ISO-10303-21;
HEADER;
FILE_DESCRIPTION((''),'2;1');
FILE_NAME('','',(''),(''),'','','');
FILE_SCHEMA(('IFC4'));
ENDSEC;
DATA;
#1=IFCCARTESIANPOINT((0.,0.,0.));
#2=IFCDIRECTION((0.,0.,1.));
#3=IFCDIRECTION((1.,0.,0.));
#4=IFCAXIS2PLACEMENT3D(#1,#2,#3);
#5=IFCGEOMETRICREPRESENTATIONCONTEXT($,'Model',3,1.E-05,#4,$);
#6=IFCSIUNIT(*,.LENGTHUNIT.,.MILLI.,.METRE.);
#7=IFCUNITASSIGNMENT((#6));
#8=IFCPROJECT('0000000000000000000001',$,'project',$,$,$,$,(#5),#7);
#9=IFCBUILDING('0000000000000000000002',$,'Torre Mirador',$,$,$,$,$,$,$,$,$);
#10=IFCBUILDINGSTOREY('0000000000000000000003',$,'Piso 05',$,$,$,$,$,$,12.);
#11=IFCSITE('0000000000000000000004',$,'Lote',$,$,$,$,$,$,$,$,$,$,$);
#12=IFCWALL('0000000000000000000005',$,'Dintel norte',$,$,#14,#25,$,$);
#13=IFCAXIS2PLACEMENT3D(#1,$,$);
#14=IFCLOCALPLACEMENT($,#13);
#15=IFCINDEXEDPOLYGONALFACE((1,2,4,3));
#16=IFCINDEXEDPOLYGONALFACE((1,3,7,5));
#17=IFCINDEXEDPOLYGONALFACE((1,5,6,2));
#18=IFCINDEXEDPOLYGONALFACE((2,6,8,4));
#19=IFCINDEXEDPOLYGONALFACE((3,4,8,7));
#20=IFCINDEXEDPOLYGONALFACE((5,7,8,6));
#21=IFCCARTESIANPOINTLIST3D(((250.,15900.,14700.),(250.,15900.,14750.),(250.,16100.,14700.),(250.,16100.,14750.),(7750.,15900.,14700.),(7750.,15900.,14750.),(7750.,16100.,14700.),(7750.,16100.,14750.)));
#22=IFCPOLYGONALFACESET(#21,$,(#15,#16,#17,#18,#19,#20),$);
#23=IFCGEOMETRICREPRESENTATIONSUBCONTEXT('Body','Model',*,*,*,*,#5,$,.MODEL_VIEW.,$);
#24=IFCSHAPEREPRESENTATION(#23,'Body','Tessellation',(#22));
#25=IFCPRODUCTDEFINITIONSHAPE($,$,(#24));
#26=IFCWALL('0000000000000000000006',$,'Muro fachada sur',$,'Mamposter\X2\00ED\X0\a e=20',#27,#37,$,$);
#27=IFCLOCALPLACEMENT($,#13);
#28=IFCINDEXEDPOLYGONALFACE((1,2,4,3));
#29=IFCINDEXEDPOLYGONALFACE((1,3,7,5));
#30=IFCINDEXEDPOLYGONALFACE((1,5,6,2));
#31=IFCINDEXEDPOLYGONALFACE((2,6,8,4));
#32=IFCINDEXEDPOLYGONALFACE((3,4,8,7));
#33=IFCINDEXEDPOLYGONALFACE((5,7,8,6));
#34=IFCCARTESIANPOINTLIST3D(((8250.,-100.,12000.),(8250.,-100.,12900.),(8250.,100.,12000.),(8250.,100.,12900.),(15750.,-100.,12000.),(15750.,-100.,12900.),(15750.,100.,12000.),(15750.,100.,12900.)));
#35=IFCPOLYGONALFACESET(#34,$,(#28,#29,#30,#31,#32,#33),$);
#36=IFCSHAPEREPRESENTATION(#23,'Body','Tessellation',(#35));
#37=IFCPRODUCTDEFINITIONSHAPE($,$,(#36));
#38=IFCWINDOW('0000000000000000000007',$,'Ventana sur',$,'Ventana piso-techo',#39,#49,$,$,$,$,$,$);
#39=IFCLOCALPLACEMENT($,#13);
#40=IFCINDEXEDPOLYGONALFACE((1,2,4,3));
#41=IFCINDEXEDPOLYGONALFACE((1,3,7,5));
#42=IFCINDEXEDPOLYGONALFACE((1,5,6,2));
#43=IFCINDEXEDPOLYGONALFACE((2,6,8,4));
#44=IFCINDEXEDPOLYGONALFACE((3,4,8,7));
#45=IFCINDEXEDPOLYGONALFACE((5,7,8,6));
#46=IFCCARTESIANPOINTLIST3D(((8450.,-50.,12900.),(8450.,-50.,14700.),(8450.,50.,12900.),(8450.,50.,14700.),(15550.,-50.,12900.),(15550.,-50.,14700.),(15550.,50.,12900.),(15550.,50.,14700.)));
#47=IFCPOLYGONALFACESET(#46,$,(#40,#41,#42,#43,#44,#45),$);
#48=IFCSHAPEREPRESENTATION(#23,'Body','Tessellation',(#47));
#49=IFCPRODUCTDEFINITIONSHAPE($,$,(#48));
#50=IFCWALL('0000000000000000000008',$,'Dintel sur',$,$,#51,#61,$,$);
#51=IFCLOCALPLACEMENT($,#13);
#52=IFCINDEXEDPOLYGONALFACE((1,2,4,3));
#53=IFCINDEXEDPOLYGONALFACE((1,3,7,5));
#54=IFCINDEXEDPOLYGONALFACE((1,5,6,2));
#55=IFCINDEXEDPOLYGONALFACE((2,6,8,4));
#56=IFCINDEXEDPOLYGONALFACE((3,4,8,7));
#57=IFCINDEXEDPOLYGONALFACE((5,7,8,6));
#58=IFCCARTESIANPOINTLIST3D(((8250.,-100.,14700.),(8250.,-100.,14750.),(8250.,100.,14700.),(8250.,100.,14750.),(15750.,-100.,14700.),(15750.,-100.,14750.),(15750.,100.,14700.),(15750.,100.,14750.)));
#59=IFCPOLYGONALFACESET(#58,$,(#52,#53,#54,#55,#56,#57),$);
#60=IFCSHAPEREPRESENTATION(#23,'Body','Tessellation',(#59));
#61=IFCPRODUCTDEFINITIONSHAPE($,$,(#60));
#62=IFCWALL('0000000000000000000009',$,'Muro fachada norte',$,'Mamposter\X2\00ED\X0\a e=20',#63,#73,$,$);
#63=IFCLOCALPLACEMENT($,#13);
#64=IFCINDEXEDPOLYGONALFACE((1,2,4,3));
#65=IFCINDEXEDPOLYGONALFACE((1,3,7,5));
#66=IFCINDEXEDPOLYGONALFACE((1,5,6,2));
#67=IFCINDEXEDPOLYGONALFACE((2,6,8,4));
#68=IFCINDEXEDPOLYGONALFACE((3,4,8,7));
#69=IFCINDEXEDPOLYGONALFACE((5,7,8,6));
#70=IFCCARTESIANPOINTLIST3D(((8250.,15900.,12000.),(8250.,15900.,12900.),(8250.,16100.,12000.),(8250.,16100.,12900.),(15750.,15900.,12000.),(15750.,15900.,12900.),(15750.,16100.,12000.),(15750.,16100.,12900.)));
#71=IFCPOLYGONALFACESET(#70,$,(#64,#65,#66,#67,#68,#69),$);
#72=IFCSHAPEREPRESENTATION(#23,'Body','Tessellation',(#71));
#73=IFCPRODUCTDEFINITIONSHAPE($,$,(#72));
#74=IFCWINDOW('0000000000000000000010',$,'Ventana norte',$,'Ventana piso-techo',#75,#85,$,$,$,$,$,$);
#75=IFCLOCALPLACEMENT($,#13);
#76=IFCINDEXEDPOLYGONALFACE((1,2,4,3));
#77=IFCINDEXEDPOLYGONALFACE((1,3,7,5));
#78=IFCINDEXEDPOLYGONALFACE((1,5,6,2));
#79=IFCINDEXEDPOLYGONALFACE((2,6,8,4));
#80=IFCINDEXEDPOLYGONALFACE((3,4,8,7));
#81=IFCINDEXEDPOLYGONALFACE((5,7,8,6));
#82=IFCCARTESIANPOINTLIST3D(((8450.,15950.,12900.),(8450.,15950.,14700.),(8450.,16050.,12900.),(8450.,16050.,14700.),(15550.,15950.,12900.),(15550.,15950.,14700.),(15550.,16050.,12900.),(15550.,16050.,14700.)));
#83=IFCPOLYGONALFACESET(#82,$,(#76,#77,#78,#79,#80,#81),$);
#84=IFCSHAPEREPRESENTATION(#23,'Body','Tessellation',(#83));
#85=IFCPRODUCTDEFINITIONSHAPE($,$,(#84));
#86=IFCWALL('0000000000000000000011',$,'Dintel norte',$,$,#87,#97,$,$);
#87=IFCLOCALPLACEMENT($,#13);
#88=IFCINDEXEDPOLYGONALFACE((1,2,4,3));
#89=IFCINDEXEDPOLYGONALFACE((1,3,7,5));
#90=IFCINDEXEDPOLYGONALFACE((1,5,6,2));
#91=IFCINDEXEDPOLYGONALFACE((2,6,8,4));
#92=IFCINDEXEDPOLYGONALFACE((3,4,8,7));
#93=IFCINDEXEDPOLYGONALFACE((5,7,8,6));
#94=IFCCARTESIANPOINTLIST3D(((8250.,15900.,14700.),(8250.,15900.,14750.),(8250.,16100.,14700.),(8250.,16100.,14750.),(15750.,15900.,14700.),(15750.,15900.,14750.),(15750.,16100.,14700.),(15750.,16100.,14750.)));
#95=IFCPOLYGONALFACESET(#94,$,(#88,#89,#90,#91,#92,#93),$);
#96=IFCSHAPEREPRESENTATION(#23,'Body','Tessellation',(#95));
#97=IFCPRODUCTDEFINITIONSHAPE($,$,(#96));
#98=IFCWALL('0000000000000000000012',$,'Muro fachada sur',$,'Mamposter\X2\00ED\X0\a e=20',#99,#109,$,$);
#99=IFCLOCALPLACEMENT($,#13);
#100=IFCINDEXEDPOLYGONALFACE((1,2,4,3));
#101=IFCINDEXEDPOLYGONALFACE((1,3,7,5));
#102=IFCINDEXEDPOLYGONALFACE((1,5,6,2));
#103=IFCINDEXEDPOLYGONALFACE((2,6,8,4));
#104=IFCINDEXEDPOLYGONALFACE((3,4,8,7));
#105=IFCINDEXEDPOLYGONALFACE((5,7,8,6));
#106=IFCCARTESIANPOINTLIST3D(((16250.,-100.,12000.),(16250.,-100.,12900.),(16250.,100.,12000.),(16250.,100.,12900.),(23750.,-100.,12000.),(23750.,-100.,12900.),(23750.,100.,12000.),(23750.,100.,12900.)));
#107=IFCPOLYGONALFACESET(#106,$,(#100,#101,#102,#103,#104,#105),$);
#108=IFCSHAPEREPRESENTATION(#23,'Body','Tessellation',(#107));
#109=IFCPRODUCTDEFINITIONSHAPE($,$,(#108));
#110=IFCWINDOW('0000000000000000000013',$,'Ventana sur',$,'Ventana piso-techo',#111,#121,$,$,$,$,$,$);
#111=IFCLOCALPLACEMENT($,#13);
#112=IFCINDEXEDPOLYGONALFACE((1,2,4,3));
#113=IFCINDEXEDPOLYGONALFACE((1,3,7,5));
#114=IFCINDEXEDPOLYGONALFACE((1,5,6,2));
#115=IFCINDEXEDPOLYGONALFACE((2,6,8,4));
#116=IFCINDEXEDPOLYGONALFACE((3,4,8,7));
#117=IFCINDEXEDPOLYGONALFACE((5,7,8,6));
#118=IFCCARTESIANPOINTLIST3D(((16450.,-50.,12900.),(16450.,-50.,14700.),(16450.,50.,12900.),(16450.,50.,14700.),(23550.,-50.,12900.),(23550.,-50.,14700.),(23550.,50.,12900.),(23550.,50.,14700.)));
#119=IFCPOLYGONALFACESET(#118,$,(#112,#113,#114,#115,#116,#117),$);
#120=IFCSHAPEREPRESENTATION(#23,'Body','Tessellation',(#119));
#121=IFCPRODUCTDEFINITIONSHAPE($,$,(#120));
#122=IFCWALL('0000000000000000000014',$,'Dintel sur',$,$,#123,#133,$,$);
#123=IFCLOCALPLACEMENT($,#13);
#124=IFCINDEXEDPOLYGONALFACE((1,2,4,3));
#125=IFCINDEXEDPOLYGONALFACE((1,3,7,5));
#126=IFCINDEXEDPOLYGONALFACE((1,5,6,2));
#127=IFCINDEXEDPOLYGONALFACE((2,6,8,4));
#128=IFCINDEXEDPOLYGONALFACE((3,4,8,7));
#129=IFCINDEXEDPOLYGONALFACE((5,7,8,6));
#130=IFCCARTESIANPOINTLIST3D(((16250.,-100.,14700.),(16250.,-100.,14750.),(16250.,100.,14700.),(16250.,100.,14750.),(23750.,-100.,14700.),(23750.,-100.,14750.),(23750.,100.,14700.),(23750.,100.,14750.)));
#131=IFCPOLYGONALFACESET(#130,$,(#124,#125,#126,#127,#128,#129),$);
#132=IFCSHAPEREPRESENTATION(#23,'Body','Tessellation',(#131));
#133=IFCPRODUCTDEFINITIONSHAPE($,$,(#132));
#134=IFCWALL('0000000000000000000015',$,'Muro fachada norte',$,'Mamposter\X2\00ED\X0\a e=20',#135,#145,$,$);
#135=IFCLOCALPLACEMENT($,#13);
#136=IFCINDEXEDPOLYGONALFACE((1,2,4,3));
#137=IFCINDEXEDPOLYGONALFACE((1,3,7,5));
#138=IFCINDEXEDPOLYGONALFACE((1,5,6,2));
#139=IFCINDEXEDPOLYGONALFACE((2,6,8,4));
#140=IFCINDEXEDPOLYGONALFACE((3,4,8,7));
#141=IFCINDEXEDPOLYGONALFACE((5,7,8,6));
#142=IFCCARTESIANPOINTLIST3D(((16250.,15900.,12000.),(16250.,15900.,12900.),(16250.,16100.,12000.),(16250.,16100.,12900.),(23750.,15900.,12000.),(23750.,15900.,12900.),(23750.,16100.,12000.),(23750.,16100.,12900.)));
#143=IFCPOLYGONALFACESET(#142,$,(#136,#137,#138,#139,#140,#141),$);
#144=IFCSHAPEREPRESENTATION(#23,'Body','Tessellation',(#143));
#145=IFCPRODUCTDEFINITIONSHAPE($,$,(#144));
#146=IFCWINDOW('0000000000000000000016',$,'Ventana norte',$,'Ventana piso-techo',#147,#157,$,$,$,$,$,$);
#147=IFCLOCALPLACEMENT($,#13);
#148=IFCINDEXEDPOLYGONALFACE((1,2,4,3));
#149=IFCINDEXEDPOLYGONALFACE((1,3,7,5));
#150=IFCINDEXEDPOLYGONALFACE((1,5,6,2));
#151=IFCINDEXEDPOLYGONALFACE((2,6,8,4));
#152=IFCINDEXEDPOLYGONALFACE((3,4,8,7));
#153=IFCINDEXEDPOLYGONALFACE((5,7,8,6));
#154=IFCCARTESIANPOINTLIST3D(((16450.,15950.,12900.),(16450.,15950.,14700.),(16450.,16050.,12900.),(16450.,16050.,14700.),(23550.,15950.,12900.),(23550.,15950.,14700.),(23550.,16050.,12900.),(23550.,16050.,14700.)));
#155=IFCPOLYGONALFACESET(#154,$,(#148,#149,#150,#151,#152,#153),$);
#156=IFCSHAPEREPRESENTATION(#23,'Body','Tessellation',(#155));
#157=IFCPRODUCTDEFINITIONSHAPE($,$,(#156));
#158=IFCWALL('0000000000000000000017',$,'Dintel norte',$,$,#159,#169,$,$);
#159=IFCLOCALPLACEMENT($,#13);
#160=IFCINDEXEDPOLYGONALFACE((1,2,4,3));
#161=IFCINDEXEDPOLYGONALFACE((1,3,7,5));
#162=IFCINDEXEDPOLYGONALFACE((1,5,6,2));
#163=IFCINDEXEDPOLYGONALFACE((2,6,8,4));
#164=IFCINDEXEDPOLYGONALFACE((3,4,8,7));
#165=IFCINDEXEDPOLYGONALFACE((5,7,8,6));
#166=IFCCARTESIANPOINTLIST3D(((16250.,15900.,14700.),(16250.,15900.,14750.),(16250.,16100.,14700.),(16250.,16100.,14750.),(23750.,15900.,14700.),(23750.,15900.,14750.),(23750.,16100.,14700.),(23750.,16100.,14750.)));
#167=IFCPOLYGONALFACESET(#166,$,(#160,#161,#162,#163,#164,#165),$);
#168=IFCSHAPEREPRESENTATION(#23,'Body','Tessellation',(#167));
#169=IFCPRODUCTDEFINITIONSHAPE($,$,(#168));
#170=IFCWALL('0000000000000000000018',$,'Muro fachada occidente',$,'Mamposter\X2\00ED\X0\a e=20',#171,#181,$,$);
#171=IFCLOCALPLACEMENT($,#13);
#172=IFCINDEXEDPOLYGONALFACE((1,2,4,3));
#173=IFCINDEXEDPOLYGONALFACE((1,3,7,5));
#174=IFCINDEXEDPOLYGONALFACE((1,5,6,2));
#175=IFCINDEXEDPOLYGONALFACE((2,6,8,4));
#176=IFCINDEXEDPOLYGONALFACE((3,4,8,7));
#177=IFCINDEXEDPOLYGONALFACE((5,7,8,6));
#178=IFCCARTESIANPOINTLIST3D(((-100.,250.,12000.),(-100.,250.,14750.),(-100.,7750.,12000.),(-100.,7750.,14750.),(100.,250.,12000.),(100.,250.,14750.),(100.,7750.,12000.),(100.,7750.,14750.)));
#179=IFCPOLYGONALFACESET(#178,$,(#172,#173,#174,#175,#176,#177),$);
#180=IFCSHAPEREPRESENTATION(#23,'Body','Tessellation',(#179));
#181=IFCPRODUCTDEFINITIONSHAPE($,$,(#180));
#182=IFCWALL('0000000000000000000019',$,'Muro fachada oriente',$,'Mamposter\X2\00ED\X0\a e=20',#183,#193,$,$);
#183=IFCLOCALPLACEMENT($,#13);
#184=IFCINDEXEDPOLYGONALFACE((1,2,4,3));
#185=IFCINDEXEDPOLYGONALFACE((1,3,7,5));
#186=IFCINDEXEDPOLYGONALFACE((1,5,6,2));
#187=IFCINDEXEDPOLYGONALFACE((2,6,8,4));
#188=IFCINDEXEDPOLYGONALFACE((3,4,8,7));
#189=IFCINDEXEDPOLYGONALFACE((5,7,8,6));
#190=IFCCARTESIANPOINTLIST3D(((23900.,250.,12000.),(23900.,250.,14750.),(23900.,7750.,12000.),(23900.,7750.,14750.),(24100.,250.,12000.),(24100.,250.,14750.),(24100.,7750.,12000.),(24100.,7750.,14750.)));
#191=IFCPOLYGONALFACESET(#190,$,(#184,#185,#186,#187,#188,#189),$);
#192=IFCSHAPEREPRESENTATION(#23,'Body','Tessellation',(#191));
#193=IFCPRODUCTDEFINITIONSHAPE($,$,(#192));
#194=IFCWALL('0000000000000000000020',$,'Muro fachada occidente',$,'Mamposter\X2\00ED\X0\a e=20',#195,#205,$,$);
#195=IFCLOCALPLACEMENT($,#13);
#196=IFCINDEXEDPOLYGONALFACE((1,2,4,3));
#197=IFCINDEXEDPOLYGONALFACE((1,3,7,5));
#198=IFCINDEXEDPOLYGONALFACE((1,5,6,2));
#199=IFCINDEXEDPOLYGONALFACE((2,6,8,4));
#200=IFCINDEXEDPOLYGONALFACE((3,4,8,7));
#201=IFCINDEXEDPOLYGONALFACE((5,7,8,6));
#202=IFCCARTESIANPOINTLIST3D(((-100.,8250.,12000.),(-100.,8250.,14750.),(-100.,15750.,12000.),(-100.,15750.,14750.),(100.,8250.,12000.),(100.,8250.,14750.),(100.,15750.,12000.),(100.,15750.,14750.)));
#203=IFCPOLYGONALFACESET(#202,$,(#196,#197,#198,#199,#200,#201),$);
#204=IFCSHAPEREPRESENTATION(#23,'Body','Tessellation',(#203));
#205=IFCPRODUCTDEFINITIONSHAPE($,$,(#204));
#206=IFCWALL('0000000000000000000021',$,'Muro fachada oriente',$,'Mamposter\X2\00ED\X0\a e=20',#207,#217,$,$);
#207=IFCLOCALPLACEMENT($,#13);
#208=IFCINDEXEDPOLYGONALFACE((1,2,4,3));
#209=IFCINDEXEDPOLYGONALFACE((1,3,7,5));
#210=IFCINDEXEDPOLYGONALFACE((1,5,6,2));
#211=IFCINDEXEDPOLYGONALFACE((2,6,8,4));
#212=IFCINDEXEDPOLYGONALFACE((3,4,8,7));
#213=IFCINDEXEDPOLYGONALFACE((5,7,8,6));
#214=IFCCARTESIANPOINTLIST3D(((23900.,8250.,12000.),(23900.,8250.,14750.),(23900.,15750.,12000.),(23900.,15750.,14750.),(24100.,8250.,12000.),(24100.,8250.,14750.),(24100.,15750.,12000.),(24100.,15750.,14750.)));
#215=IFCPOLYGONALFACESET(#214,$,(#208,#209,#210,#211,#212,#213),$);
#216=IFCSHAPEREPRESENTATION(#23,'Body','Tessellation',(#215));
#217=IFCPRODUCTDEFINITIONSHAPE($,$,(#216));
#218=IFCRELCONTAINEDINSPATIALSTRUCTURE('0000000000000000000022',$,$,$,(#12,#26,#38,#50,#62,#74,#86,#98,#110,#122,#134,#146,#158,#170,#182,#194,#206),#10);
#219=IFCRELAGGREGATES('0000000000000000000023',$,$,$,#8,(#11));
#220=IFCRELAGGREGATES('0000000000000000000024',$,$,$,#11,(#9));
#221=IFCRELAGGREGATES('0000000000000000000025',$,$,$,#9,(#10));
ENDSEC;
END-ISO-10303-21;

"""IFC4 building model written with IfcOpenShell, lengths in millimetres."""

from ifc_helpers import new_model, si_unit, frame, origin_with_axes, place, context, subcontext, project, spatial, indexed_curve, outline, extrude, element, save


model = new_model("IFC4")

# Units and contexts
model_context = context("Model", 3, precision=1e-05, world=origin_with_axes())
body_context = subcontext(model_context, "Body", "Model", "MODEL_VIEW")
ifc_project = project(units=[si_unit("LENGTHUNIT", "METRE", prefix="MILLI")], contexts=[model_context])

# Site, building, storey
site = spatial("IfcSite", under=ifc_project, Name="Lote")
building = spatial("IfcBuilding", under=site, Name="Torre Mirador")
storey = spatial("IfcBuildingStorey", under=building, Name="Piso 05", Elevation=12.0)

# Walls
wall_1_placement = place(None, frame((250.0, 15900.0, 14700.0), z_axis=(0.0, 0.0, 1.0), x_axis=(1.0, 0.0, 0.0)))
element("IfcWall", 1, at=wall_1_placement, inside=storey, Name="Dintel norte", context=body_context, shape_type="SweptSolid", body=[
    extrude(outline(indexed_curve([(0.0, 0.0), (0.0, 200.0), (7500.0, 200.0), (7500.0, 0.0), (0.0, 0.0)], self_intersect=False)), origin_with_axes(), (0.0, 0.0, 1.0), 50.0),
])
wall_2_placement = place(None, frame((8250.0, -100.0, 12000.0), z_axis=(0.0, 0.0, 1.0), x_axis=(1.0, 0.0, 0.0)))
element("IfcWall", 2, at=wall_2_placement, inside=storey, Name="Muro fachada sur", ObjectType="Mampostería e=20", context=body_context, shape_type="SweptSolid", body=[
    extrude(outline(indexed_curve([(0.0, 0.0), (0.0, 200.0), (7500.0, 200.0), (7500.0, 0.0), (0.0, 0.0)], self_intersect=False)), origin_with_axes(), (0.0, 0.0, 1.0), 900.0),
])

# Window
window_1_placement = place(None, frame((8450.0, -50.0, 12900.0), z_axis=(0.0, 0.0, 1.0), x_axis=(1.0, 0.0, 0.0)))
element("IfcWindow", 3, at=window_1_placement, inside=storey, Name="Ventana sur", ObjectType="Ventana piso-techo", context=body_context, shape_type="SweptSolid", body=[
    extrude(outline(indexed_curve([(0.0, 0.0), (0.0, 100.0), (7100.0, 100.0), (7100.0, 0.0), (0.0, 0.0)], self_intersect=False)), origin_with_axes(), (0.0, 0.0, 1.0), 1800.0),
])

# Walls
wall_3_placement = place(None, frame((8250.0, -100.0, 14700.0), z_axis=(0.0, 0.0, 1.0), x_axis=(1.0, 0.0, 0.0)))
element("IfcWall", 4, at=wall_3_placement, inside=storey, Name="Dintel sur", context=body_context, shape_type="SweptSolid", body=[
    extrude(outline(indexed_curve([(0.0, 0.0), (0.0, 200.0), (7500.0, 200.0), (7500.0, 0.0), (0.0, 0.0)], self_intersect=False)), origin_with_axes(), (0.0, 0.0, 1.0), 50.0),
])
wall_4_placement = place(None, frame((8250.0, 15900.0, 12000.0), z_axis=(0.0, 0.0, 1.0), x_axis=(1.0, 0.0, 0.0)))
element("IfcWall", 5, at=wall_4_placement, inside=storey, Name="Muro fachada norte", ObjectType="Mampostería e=20", context=body_context, shape_type="SweptSolid", body=[
    extrude(outline(indexed_curve([(0.0, 0.0), (0.0, 200.0), (7500.0, 200.0), (7500.0, 0.0), (0.0, 0.0)], self_intersect=False)), origin_with_axes(), (0.0, 0.0, 1.0), 900.0),
])

# Window
window_2_placement = place(None, frame((8450.0, 15950.0, 12900.0), z_axis=(0.0, 0.0, 1.0), x_axis=(1.0, 0.0, 0.0)))
element("IfcWindow", 6, at=window_2_placement, inside=storey, Name="Ventana norte", ObjectType="Ventana piso-techo", context=body_context, shape_type="SweptSolid", body=[
    extrude(outline(indexed_curve([(0.0, 0.0), (0.0, 100.0), (7100.0, 100.0), (7100.0, 0.0), (0.0, 0.0)], self_intersect=False)), origin_with_axes(), (0.0, 0.0, 1.0), 1800.0),
])

# Walls
wall_5_placement = place(None, frame((8250.0, 15900.0, 14700.0), z_axis=(0.0, 0.0, 1.0), x_axis=(1.0, 0.0, 0.0)))
element("IfcWall", 7, at=wall_5_placement, inside=storey, Name="Dintel norte", context=body_context, shape_type="SweptSolid", body=[
    extrude(outline(indexed_curve([(0.0, 0.0), (0.0, 200.0), (7500.0, 200.0), (7500.0, 0.0), (0.0, 0.0)], self_intersect=False)), origin_with_axes(), (0.0, 0.0, 1.0), 50.0),
])
wall_6_placement = place(None, frame((16250.0, -100.0, 12000.0), z_axis=(0.0, 0.0, 1.0), x_axis=(1.0, 0.0, 0.0)))
element("IfcWall", 8, at=wall_6_placement, inside=storey, Name="Muro fachada sur", ObjectType="Mampostería e=20", context=body_context, shape_type="SweptSolid", body=[
    extrude(outline(indexed_curve([(0.0, 0.0), (0.0, 200.0), (7500.0, 200.0), (7500.0, 0.0), (0.0, 0.0)], self_intersect=False)), origin_with_axes(), (0.0, 0.0, 1.0), 900.0),
])

# Window
window_3_placement = place(None, frame((16450.0, -50.0, 12900.0), z_axis=(0.0, 0.0, 1.0), x_axis=(1.0, 0.0, 0.0)))
element("IfcWindow", 9, at=window_3_placement, inside=storey, Name="Ventana sur", ObjectType="Ventana piso-techo", context=body_context, shape_type="SweptSolid", body=[
    extrude(outline(indexed_curve([(0.0, 0.0), (0.0, 100.0), (7100.0, 100.0), (7100.0, 0.0), (0.0, 0.0)], self_intersect=False)), origin_with_axes(), (0.0, 0.0, 1.0), 1800.0),
])

# Walls
wall_7_placement = place(None, frame((16250.0, -100.0, 14700.0), z_axis=(0.0, 0.0, 1.0), x_axis=(1.0, 0.0, 0.0)))
element("IfcWall", 10, at=wall_7_placement, inside=storey, Name="Dintel sur", context=body_context, shape_type="SweptSolid", body=[
    extrude(outline(indexed_curve([(0.0, 0.0), (0.0, 200.0), (7500.0, 200.0), (7500.0, 0.0), (0.0, 0.0)], self_intersect=False)), origin_with_axes(), (0.0, 0.0, 1.0), 50.0),
])
wall_8_placement = place(None, frame((16250.0, 15900.0, 12000.0), z_axis=(0.0, 0.0, 1.0), x_axis=(1.0, 0.0, 0.0)))
element("IfcWall", 11, at=wall_8_placement, inside=storey, Name="Muro fachada norte", ObjectType="Mampostería e=20", context=body_context, shape_type="SweptSolid", body=[
    extrude(outline(indexed_curve([(0.0, 0.0), (0.0, 200.0), (7500.0, 200.0), (7500.0, 0.0), (0.0, 0.0)], self_intersect=False)), origin_with_axes(), (0.0, 0.0, 1.0), 900.0),
])

# Window
window_4_placement = place(None, frame((16450.0, 15950.0, 12900.0), z_axis=(0.0, 0.0, 1.0), x_axis=(1.0, 0.0, 0.0)))
element("IfcWindow", 12, at=window_4_placement, inside=storey, Name="Ventana norte", ObjectType="Ventana piso-techo", context=body_context, shape_type="SweptSolid", body=[
    extrude(outline(indexed_curve([(0.0, 0.0), (0.0, 100.0), (7100.0, 100.0), (7100.0, 0.0), (0.0, 0.0)], self_intersect=False)), origin_with_axes(), (0.0, 0.0, 1.0), 1800.0),
])

# Walls
wall_9_placement = place(None, frame((16250.0, 15900.0, 14700.0), z_axis=(0.0, 0.0, 1.0), x_axis=(1.0, 0.0, 0.0)))
element("IfcWall", 13, at=wall_9_placement, inside=storey, Name="Dintel norte", context=body_context, shape_type="SweptSolid", body=[
    extrude(outline(indexed_curve([(0.0, 0.0), (0.0, 200.0), (7500.0, 200.0), (7500.0, 0.0), (0.0, 0.0)], self_intersect=False)), origin_with_axes(), (0.0, 0.0, 1.0), 50.0),
])
for number, where, z_axis, x_axis, name in (
    (14, (-100.0, 250.0, 12000.0), (0.0, 0.0, 1.0), (1.0, 0.0, 0.0), "Muro fachada occidente"),
    (15, (23900.0, 250.0, 12000.0), (0.0, 0.0, 1.0), (1.0, 0.0, 0.0), "Muro fachada oriente"),
    (16, (-100.0, 8250.0, 12000.0), (0.0, 0.0, 1.0), (1.0, 0.0, 0.0), "Muro fachada occidente"),
    (17, (23900.0, 8250.0, 12000.0), (0.0, 0.0, 1.0), (1.0, 0.0, 0.0), "Muro fachada oriente"),
):
    element("IfcWall", number, at=place(None, frame(where, z_axis=z_axis, x_axis=x_axis)), inside=storey, Name=name, ObjectType="Mampostería e=20", context=body_context, shape_type="SweptSolid", body=[
        extrude(outline(indexed_curve([(0.0, 0.0), (0.0, 7500.0), (200.0, 7500.0), (200.0, 0.0), (0.0, 0.0)], self_intersect=False)), origin_with_axes(), (0.0, 0.0, 1.0), 2750.0),
    ])

save(model, "model.ifc")
